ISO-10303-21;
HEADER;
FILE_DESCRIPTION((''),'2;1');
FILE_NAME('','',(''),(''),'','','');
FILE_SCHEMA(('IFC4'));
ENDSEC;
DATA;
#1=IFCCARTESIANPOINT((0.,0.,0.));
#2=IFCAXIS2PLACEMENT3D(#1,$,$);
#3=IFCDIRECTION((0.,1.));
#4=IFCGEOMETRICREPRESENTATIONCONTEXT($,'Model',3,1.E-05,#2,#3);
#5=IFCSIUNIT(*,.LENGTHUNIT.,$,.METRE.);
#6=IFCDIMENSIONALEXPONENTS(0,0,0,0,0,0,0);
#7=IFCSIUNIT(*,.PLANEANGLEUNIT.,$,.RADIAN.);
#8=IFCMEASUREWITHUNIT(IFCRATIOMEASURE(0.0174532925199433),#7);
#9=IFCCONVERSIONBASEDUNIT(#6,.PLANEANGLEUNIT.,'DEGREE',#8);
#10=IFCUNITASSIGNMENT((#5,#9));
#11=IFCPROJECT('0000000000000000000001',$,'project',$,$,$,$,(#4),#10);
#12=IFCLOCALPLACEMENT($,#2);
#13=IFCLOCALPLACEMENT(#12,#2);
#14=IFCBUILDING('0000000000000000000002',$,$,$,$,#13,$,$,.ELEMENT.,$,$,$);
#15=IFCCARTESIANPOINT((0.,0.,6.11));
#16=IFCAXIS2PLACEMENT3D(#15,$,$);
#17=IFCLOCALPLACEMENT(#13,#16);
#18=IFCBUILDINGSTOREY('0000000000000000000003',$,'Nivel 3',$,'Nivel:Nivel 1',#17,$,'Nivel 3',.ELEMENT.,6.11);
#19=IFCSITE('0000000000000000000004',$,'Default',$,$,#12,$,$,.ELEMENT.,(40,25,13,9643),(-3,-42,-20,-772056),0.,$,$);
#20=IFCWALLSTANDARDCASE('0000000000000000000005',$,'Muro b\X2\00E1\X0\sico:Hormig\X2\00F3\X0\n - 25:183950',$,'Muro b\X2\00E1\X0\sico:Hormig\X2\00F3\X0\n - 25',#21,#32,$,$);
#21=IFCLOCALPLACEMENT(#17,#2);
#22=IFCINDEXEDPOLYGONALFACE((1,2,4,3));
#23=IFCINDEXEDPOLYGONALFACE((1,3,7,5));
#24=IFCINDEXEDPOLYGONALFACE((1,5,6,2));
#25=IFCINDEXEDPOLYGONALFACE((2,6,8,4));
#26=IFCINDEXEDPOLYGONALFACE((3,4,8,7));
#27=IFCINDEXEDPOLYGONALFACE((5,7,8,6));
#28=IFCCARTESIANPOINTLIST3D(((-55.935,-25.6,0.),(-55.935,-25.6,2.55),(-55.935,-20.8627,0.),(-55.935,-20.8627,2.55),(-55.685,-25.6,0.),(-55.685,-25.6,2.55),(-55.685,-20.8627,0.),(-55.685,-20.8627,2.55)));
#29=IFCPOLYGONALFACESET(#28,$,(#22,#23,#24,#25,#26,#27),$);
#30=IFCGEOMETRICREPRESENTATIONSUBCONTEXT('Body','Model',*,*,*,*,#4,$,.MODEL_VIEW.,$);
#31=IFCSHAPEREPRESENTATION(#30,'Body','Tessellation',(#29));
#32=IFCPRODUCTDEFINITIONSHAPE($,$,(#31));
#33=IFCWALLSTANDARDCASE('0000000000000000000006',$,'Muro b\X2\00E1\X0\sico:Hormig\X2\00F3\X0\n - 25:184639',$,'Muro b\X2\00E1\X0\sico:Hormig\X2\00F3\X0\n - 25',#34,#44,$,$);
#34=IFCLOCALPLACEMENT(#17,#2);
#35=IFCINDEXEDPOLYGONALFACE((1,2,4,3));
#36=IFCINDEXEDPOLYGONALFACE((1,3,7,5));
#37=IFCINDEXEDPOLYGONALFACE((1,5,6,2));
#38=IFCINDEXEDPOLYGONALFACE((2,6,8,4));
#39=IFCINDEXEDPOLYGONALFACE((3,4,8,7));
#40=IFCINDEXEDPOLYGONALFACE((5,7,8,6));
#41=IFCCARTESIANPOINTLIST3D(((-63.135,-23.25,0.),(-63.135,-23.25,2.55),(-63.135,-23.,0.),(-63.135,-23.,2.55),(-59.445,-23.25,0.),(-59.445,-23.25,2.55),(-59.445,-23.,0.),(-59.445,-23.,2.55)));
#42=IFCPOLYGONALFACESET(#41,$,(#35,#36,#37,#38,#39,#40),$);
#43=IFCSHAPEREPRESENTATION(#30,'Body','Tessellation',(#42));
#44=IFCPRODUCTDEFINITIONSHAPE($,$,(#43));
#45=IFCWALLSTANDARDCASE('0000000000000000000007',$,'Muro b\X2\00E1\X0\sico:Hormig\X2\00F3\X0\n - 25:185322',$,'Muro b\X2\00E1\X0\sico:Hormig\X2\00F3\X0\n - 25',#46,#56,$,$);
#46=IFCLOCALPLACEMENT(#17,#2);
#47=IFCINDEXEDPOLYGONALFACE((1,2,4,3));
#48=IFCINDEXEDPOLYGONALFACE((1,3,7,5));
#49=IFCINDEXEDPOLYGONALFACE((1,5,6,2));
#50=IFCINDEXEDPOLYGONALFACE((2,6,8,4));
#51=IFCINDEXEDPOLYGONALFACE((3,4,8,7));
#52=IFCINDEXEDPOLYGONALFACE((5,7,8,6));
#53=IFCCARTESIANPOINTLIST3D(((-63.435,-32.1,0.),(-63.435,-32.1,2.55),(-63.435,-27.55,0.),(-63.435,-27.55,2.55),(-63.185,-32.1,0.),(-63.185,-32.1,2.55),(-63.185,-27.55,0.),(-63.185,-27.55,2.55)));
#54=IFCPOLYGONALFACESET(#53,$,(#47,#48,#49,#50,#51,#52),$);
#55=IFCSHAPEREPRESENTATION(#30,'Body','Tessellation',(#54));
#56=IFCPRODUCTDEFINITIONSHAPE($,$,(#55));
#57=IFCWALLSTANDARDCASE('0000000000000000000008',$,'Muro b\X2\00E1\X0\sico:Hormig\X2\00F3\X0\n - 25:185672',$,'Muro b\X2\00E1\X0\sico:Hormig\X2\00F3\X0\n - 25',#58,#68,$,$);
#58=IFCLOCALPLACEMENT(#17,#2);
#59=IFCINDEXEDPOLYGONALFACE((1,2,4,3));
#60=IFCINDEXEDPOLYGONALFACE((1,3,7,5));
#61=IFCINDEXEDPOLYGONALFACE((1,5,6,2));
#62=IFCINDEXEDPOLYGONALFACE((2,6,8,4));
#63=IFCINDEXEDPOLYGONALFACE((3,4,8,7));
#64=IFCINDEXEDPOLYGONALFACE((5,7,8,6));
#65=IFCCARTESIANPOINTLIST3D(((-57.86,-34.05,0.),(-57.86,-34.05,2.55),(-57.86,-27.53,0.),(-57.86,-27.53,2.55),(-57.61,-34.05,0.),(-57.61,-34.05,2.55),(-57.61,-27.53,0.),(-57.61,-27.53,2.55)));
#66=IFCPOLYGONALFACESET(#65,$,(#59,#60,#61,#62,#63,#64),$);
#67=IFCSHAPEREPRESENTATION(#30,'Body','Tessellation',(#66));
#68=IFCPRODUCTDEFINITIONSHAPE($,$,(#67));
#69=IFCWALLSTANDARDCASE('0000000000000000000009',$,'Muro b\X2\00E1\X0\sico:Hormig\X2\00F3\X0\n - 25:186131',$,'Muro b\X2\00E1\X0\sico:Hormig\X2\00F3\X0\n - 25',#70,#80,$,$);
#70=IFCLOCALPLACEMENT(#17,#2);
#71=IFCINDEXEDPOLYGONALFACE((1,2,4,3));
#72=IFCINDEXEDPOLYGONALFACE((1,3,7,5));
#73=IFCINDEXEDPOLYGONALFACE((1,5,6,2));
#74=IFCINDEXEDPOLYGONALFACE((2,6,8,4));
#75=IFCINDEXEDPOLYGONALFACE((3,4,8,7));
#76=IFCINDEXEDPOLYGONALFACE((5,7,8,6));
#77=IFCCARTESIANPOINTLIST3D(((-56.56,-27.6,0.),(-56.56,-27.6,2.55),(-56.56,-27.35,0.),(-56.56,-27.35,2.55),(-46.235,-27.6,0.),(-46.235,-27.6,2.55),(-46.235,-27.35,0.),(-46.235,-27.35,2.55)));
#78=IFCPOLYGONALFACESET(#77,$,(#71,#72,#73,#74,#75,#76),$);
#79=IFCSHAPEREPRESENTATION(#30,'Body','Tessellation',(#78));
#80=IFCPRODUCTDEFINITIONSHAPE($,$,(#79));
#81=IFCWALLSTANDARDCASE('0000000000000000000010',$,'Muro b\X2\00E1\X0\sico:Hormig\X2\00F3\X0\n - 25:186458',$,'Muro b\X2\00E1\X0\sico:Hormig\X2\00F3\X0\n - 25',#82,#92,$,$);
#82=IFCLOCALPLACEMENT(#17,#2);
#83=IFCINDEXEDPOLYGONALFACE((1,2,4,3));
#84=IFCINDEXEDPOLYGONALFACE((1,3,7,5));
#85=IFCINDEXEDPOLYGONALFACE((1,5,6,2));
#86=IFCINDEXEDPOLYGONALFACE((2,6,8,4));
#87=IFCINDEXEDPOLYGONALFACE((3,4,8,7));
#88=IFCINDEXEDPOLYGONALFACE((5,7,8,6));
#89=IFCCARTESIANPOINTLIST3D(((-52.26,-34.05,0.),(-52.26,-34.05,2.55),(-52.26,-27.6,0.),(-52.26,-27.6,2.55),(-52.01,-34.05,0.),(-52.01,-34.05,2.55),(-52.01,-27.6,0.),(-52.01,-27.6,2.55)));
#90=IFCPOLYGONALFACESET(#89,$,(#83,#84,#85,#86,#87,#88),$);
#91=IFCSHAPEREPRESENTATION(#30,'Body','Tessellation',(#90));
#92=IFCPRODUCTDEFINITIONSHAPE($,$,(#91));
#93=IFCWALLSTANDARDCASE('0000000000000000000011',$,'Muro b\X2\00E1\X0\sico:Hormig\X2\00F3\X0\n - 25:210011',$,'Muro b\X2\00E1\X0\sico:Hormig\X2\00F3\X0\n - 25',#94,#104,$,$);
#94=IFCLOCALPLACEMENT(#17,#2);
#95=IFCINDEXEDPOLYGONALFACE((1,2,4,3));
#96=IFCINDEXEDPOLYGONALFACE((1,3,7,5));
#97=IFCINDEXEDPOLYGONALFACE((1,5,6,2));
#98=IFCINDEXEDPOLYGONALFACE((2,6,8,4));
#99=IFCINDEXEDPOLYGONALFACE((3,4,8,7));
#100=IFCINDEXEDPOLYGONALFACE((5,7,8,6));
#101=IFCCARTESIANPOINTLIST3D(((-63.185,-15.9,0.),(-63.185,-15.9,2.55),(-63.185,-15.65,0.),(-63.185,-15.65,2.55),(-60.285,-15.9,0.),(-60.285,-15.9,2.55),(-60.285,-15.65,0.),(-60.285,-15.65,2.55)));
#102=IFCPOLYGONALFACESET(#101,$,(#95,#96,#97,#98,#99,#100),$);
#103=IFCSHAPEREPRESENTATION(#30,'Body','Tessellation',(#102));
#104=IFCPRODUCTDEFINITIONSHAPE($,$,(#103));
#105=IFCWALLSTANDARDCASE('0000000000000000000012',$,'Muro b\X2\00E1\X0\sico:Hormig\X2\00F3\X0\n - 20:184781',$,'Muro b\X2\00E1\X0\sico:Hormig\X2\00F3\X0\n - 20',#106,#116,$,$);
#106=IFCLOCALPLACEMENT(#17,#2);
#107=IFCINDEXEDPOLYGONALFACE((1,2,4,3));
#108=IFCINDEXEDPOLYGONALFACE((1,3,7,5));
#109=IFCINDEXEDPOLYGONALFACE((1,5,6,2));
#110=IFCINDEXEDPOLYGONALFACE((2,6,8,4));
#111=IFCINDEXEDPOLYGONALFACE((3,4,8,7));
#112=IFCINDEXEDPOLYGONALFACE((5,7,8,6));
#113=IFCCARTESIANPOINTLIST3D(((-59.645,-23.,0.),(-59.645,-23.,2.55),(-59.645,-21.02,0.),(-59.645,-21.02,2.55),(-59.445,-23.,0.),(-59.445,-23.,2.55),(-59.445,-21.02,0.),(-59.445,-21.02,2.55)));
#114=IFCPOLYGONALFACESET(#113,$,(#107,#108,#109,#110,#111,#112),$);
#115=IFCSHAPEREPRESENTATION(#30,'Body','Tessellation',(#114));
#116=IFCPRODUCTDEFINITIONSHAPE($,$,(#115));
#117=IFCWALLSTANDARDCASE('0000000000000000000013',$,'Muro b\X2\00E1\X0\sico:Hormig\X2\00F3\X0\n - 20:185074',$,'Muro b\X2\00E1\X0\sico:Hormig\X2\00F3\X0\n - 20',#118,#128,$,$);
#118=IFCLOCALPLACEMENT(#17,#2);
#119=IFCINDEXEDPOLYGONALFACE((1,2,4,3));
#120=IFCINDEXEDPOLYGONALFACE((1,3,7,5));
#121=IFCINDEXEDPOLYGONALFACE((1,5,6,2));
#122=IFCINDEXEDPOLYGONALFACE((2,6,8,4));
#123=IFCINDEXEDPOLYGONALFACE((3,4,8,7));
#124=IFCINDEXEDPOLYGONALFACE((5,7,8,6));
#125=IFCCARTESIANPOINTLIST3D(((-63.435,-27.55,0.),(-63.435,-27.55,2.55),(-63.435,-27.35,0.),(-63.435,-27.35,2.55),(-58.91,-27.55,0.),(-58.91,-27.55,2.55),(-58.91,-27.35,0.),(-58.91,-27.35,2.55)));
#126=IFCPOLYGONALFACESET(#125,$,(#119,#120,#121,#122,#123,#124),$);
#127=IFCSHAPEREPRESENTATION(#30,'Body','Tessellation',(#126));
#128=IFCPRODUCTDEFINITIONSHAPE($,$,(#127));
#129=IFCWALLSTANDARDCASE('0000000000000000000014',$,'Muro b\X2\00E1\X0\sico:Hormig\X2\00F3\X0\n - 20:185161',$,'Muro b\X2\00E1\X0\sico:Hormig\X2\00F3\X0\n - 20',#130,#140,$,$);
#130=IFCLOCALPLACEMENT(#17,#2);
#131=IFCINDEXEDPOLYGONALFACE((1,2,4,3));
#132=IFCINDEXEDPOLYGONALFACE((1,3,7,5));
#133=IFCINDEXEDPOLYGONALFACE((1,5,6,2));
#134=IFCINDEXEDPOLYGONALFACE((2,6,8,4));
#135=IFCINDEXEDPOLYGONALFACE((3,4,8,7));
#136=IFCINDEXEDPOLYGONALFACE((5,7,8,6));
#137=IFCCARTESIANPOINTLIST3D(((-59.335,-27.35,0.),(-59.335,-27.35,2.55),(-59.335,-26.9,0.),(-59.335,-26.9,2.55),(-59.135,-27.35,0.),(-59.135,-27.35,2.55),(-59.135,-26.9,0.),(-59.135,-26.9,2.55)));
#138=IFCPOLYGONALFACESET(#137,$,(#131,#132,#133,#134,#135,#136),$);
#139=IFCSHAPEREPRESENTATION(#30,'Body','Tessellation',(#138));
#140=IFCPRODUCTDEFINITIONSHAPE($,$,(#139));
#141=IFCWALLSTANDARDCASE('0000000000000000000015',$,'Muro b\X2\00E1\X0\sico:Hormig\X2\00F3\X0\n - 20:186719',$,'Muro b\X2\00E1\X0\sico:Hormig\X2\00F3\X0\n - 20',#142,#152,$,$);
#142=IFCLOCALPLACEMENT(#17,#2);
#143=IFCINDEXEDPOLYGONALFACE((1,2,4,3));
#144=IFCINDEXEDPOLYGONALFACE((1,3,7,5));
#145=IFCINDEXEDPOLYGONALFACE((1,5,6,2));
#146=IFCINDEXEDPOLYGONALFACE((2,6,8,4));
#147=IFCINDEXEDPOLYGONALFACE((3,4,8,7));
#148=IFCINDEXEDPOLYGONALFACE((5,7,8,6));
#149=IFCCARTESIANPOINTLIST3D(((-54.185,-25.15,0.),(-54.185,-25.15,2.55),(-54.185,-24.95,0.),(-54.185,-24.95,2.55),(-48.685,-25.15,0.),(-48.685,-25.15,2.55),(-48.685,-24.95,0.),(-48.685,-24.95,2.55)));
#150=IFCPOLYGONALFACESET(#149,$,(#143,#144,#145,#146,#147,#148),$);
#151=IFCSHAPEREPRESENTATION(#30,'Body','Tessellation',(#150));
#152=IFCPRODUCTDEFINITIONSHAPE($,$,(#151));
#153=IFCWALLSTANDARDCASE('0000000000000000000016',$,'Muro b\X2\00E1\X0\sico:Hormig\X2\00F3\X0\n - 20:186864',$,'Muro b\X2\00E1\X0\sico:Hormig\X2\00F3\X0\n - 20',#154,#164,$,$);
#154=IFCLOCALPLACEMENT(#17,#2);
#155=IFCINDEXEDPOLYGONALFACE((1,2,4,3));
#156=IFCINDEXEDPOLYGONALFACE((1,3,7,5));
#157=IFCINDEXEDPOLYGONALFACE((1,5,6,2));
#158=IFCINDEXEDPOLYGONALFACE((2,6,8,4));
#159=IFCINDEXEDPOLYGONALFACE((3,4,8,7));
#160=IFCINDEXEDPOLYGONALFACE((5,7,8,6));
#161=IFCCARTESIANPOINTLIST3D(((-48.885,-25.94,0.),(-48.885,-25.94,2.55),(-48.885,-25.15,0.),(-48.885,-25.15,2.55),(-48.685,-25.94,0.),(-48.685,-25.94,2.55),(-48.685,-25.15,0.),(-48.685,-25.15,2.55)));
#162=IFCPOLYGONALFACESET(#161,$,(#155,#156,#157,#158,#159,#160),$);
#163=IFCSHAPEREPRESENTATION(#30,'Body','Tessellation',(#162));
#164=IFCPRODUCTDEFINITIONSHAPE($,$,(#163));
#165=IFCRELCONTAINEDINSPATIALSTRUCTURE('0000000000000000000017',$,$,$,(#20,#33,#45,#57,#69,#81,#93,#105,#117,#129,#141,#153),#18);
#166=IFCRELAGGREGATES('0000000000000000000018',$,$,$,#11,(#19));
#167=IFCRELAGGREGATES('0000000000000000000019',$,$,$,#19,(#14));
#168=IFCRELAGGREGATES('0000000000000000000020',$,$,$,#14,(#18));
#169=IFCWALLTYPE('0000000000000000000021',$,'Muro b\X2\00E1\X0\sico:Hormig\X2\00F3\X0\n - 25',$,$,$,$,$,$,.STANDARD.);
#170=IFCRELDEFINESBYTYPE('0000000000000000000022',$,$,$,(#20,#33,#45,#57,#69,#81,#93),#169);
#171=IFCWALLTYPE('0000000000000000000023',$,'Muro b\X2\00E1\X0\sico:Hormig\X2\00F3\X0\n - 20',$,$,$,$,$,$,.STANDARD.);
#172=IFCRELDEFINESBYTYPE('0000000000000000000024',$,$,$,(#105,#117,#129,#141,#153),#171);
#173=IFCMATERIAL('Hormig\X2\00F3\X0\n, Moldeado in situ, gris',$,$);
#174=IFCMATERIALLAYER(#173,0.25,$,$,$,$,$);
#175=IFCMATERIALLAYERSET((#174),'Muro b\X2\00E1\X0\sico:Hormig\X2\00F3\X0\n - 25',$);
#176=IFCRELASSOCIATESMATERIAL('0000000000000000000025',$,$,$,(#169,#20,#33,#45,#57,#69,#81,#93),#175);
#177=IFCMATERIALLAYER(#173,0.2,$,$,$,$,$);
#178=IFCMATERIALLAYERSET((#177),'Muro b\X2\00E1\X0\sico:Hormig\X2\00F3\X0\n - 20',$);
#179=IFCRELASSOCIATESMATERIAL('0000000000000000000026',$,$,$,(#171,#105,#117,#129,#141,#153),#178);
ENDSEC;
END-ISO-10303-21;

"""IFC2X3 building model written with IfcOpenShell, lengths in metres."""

from ifc_helpers import new_model, entity, si_unit, converted_unit, direction, frame, frame_2d, origin, place, context, subcontext, project, spatial, rectangle, extrude, material, layer, layer_set, layer_usage, type_object, element, save


model = new_model("IFC2X3")

# Units and contexts
model_context = context("Model", 3, precision=1e-05, world=origin(), true_north=direction((0.0, 1.0)))
body_context = subcontext(model_context, "Body", "Model", "MODEL_VIEW")
ifc_project = project(units=[si_unit("LENGTHUNIT", "METRE"), converted_unit("PLANEANGLEUNIT", "DEGREE", entity("IfcRatioMeasure", 0.0174532925199433), si_unit("PLANEANGLEUNIT", "RADIAN"), dimensions=[0, 0, 0, 0, 0, 0, 0])], contexts=[model_context])

# Site, building, storey
site_placement = place(None, origin())
site = spatial("IfcSite", under=ifc_project, at=site_placement, Name="Default", CompositionType="ELEMENT", RefLatitude=(40, 25, 13, 9643), RefLongitude=(-3, -42, -20, -772056), RefElevation=0.0)
building_placement = place(site_placement, origin())
building = spatial("IfcBuilding", under=site, at=building_placement, CompositionType="ELEMENT")
storey_placement = place(building_placement, frame((0.0, 0.0, 6.11)))
storey = spatial("IfcBuildingStorey", under=building, at=storey_placement, Name="Nivel 3", ObjectType="Nivel:Nivel 1", LongName="Nivel 3", CompositionType="ELEMENT", Elevation=6.11)

# Walls
ifc_material = material(Name="Hormigón, Moldeado in situ, gris")
ifc_layer_1 = layer(ifc_material, 0.25)
ifc_layer_set_1 = layer_set([ifc_layer_1], Name="Muro básico:Hormigón - 25")
wall_type_1 = type_object("IfcWallType", Name="Muro básico:Hormigón - 25", PredefinedType="STANDARD", material=ifc_layer_set_1)
ifc_layer_usage_1 = layer_usage(ifc_layer_set_1, "AXIS2", "NEGATIVE", 0.125)
wall_1_placement = place(storey_placement, frame((-55.81, -25.6, 0.0), z_axis=(0.0, 0.0, 1.0), x_axis=(0.0, 1.0, 0.0)))
element("IfcWallStandardCase", 1, at=wall_1_placement, inside=storey, type_object=wall_type_1, material=ifc_layer_usage_1, Name="Muro básico:Hormigón - 25:183950", ObjectType="Muro básico:Hormigón - 25", context=body_context, shape_type="SweptSolid", body=[
    extrude(rectangle(XDim=4.7373, YDim=0.25, at=frame_2d((2.3686, 0.0), x_axis=(-1.0, 0.0))), origin(), (0.0, 0.0, 1.0), 2.55),
])
ifc_layer_usage_2 = layer_usage(ifc_layer_set_1, "AXIS2", "NEGATIVE", 0.125)
wall_2_placement = place(storey_placement, frame((-63.135, -23.125, 0.0)))
element("IfcWallStandardCase", 2, at=wall_2_placement, inside=storey, type_object=wall_type_1, material=ifc_layer_usage_2, Name="Muro básico:Hormigón - 25:184639", ObjectType="Muro básico:Hormigón - 25", context=body_context, shape_type="SweptSolid", body=[
    extrude(rectangle(XDim=3.69, YDim=0.25, at=frame_2d((1.845, 0.0), x_axis=(-1.0, 0.0))), origin(), (0.0, 0.0, 1.0), 2.55),
])
ifc_layer_usage_3 = layer_usage(ifc_layer_set_1, "AXIS2", "NEGATIVE", 0.125)
wall_3_placement = place(storey_placement, frame((-63.31, -32.1, 0.0), z_axis=(0.0, 0.0, 1.0), x_axis=(0.0, 1.0, 0.0)))
element("IfcWallStandardCase", 3, at=wall_3_placement, inside=storey, type_object=wall_type_1, material=ifc_layer_usage_3, Name="Muro básico:Hormigón - 25:185322", ObjectType="Muro básico:Hormigón - 25", context=body_context, shape_type="SweptSolid", body=[
    extrude(rectangle(XDim=4.55, YDim=0.25, at=frame_2d((2.275, 0.0), x_axis=(-1.0, 0.0))), origin(), (0.0, 0.0, 1.0), 2.55),
])
ifc_layer_usage_4 = layer_usage(ifc_layer_set_1, "AXIS2", "NEGATIVE", 0.125)
wall_4_placement = place(storey_placement, frame((-57.735, -34.05, 0.0), z_axis=(0.0, 0.0, 1.0), x_axis=(0.0, 1.0, 0.0)))
element("IfcWallStandardCase", 4, at=wall_4_placement, inside=storey, type_object=wall_type_1, material=ifc_layer_usage_4, Name="Muro básico:Hormigón - 25:185672", ObjectType="Muro básico:Hormigón - 25", context=body_context, shape_type="SweptSolid", body=[
    extrude(rectangle(XDim=6.52, YDim=0.25, at=frame_2d((3.26, 0.0), x_axis=(-1.0, 0.0))), origin(), (0.0, 0.0, 1.0), 2.55),
])
ifc_layer_usage_5 = layer_usage(ifc_layer_set_1, "AXIS2", "NEGATIVE", 0.125)
wall_5_placement = place(storey_placement, frame((-56.56, -27.475, 0.0)))
element("IfcWallStandardCase", 5, at=wall_5_placement, inside=storey, type_object=wall_type_1, material=ifc_layer_usage_5, Name="Muro básico:Hormigón - 25:186131", ObjectType="Muro básico:Hormigón - 25", context=body_context, shape_type="SweptSolid", body=[
    extrude(rectangle(XDim=10.325, YDim=0.25, at=frame_2d((5.1625, 0.0), x_axis=(-1.0, 0.0))), origin(), (0.0, 0.0, 1.0), 2.55),
])
ifc_layer_usage_6 = layer_usage(ifc_layer_set_1, "AXIS2", "NEGATIVE", 0.125)
wall_6_placement = place(storey_placement, frame((-52.135, -34.05, 0.0), z_axis=(0.0, 0.0, 1.0), x_axis=(0.0, 1.0, 0.0)))
element("IfcWallStandardCase", 6, at=wall_6_placement, inside=storey, type_object=wall_type_1, material=ifc_layer_usage_6, Name="Muro básico:Hormigón - 25:186458", ObjectType="Muro básico:Hormigón - 25", context=body_context, shape_type="SweptSolid", body=[
    extrude(rectangle(XDim=6.45, YDim=0.25, at=frame_2d((3.225, 0.0), x_axis=(-1.0, 0.0))), origin(), (0.0, 0.0, 1.0), 2.55),
])
ifc_layer_usage_7 = layer_usage(ifc_layer_set_1, "AXIS2", "NEGATIVE", 0.125)
wall_7_placement = place(storey_placement, frame((-63.185, -15.775, 0.0)))
element("IfcWallStandardCase", 7, at=wall_7_placement, inside=storey, type_object=wall_type_1, material=ifc_layer_usage_7, Name="Muro básico:Hormigón - 25:210011", ObjectType="Muro básico:Hormigón - 25", context=body_context, shape_type="SweptSolid", body=[
    extrude(rectangle(XDim=2.9, YDim=0.25, at=frame_2d((1.45, 0.0), x_axis=(-1.0, 0.0))), origin(), (0.0, 0.0, 1.0), 2.55),
])
ifc_layer_2 = layer(ifc_material, 0.2)
ifc_layer_set_2 = layer_set([ifc_layer_2], Name="Muro básico:Hormigón - 20")
ifc_layer_usage_8 = layer_usage(ifc_layer_set_2, "AXIS2", "NEGATIVE", 0.1)
wall_type_2 = type_object("IfcWallType", Name="Muro básico:Hormigón - 20", PredefinedType="STANDARD", material=ifc_layer_set_2)
wall_8_placement = place(storey_placement, frame((-59.545, -23.0, 0.0), z_axis=(0.0, 0.0, 1.0), x_axis=(0.0, 1.0, 0.0)))
element("IfcWallStandardCase", 8, at=wall_8_placement, inside=storey, type_object=wall_type_2, material=ifc_layer_usage_8, Name="Muro básico:Hormigón - 20:184781", ObjectType="Muro básico:Hormigón - 20", context=body_context, shape_type="SweptSolid", body=[
    extrude(rectangle(XDim=1.98, YDim=0.2, at=frame_2d((0.99, 0.0), x_axis=(-1.0, 0.0))), origin(), (0.0, 0.0, 1.0), 2.55),
])
ifc_layer_usage_9 = layer_usage(ifc_layer_set_2, "AXIS2", "NEGATIVE", 0.1)
wall_9_placement = place(storey_placement, frame((-63.435, -27.45, 0.0)))
element("IfcWallStandardCase", 9, at=wall_9_placement, inside=storey, type_object=wall_type_2, material=ifc_layer_usage_9, Name="Muro básico:Hormigón - 20:185074", ObjectType="Muro básico:Hormigón - 20", context=body_context, shape_type="SweptSolid", body=[
    extrude(rectangle(XDim=4.525, YDim=0.2, at=frame_2d((2.2625, 0.0), x_axis=(-1.0, 0.0))), origin(), (0.0, 0.0, 1.0), 2.55),
])
ifc_layer_usage_10 = layer_usage(ifc_layer_set_2, "AXIS2", "NEGATIVE", 0.1)
wall_10_placement = place(storey_placement, frame((-59.235, -27.35, 0.0), z_axis=(0.0, 0.0, 1.0), x_axis=(0.0, 1.0, 0.0)))
element("IfcWallStandardCase", 10, at=wall_10_placement, inside=storey, type_object=wall_type_2, material=ifc_layer_usage_10, Name="Muro básico:Hormigón - 20:185161", ObjectType="Muro básico:Hormigón - 20", context=body_context, shape_type="SweptSolid", body=[
    extrude(rectangle(XDim=0.45, YDim=0.2, at=frame_2d((0.225, 0.0), x_axis=(-1.0, 0.0))), origin(), (0.0, 0.0, 1.0), 2.55),
])
ifc_layer_usage_11 = layer_usage(ifc_layer_set_2, "AXIS2", "NEGATIVE", 0.1)
wall_11_placement = place(storey_placement, frame((-54.185, -25.05, 0.0)))
element("IfcWallStandardCase", 11, at=wall_11_placement, inside=storey, type_object=wall_type_2, material=ifc_layer_usage_11, Name="Muro básico:Hormigón - 20:186719", ObjectType="Muro básico:Hormigón - 20", context=body_context, shape_type="SweptSolid", body=[
    extrude(rectangle(XDim=5.5, YDim=0.2, at=frame_2d((2.75, 0.0), x_axis=(-1.0, 0.0))), origin(), (0.0, 0.0, 1.0), 2.55),
])
ifc_layer_usage_12 = layer_usage(ifc_layer_set_2, "AXIS2", "NEGATIVE", 0.1)
wall_12_placement = place(storey_placement, frame((-48.785, -25.15, 0.0), z_axis=(0.0, 0.0, 1.0), x_axis=(0.0, -1.0, 0.0)))
element("IfcWallStandardCase", 12, at=wall_12_placement, inside=storey, type_object=wall_type_2, material=ifc_layer_usage_12, Name="Muro básico:Hormigón - 20:186864", ObjectType="Muro básico:Hormigón - 20", context=body_context, shape_type="SweptSolid", body=[
    extrude(rectangle(XDim=0.79, YDim=0.2, at=frame_2d((0.395, 0.0), x_axis=(-1.0, 0.0))), origin(), (0.0, 0.0, 1.0), 2.55),
])

save(model, "model.ifc")
